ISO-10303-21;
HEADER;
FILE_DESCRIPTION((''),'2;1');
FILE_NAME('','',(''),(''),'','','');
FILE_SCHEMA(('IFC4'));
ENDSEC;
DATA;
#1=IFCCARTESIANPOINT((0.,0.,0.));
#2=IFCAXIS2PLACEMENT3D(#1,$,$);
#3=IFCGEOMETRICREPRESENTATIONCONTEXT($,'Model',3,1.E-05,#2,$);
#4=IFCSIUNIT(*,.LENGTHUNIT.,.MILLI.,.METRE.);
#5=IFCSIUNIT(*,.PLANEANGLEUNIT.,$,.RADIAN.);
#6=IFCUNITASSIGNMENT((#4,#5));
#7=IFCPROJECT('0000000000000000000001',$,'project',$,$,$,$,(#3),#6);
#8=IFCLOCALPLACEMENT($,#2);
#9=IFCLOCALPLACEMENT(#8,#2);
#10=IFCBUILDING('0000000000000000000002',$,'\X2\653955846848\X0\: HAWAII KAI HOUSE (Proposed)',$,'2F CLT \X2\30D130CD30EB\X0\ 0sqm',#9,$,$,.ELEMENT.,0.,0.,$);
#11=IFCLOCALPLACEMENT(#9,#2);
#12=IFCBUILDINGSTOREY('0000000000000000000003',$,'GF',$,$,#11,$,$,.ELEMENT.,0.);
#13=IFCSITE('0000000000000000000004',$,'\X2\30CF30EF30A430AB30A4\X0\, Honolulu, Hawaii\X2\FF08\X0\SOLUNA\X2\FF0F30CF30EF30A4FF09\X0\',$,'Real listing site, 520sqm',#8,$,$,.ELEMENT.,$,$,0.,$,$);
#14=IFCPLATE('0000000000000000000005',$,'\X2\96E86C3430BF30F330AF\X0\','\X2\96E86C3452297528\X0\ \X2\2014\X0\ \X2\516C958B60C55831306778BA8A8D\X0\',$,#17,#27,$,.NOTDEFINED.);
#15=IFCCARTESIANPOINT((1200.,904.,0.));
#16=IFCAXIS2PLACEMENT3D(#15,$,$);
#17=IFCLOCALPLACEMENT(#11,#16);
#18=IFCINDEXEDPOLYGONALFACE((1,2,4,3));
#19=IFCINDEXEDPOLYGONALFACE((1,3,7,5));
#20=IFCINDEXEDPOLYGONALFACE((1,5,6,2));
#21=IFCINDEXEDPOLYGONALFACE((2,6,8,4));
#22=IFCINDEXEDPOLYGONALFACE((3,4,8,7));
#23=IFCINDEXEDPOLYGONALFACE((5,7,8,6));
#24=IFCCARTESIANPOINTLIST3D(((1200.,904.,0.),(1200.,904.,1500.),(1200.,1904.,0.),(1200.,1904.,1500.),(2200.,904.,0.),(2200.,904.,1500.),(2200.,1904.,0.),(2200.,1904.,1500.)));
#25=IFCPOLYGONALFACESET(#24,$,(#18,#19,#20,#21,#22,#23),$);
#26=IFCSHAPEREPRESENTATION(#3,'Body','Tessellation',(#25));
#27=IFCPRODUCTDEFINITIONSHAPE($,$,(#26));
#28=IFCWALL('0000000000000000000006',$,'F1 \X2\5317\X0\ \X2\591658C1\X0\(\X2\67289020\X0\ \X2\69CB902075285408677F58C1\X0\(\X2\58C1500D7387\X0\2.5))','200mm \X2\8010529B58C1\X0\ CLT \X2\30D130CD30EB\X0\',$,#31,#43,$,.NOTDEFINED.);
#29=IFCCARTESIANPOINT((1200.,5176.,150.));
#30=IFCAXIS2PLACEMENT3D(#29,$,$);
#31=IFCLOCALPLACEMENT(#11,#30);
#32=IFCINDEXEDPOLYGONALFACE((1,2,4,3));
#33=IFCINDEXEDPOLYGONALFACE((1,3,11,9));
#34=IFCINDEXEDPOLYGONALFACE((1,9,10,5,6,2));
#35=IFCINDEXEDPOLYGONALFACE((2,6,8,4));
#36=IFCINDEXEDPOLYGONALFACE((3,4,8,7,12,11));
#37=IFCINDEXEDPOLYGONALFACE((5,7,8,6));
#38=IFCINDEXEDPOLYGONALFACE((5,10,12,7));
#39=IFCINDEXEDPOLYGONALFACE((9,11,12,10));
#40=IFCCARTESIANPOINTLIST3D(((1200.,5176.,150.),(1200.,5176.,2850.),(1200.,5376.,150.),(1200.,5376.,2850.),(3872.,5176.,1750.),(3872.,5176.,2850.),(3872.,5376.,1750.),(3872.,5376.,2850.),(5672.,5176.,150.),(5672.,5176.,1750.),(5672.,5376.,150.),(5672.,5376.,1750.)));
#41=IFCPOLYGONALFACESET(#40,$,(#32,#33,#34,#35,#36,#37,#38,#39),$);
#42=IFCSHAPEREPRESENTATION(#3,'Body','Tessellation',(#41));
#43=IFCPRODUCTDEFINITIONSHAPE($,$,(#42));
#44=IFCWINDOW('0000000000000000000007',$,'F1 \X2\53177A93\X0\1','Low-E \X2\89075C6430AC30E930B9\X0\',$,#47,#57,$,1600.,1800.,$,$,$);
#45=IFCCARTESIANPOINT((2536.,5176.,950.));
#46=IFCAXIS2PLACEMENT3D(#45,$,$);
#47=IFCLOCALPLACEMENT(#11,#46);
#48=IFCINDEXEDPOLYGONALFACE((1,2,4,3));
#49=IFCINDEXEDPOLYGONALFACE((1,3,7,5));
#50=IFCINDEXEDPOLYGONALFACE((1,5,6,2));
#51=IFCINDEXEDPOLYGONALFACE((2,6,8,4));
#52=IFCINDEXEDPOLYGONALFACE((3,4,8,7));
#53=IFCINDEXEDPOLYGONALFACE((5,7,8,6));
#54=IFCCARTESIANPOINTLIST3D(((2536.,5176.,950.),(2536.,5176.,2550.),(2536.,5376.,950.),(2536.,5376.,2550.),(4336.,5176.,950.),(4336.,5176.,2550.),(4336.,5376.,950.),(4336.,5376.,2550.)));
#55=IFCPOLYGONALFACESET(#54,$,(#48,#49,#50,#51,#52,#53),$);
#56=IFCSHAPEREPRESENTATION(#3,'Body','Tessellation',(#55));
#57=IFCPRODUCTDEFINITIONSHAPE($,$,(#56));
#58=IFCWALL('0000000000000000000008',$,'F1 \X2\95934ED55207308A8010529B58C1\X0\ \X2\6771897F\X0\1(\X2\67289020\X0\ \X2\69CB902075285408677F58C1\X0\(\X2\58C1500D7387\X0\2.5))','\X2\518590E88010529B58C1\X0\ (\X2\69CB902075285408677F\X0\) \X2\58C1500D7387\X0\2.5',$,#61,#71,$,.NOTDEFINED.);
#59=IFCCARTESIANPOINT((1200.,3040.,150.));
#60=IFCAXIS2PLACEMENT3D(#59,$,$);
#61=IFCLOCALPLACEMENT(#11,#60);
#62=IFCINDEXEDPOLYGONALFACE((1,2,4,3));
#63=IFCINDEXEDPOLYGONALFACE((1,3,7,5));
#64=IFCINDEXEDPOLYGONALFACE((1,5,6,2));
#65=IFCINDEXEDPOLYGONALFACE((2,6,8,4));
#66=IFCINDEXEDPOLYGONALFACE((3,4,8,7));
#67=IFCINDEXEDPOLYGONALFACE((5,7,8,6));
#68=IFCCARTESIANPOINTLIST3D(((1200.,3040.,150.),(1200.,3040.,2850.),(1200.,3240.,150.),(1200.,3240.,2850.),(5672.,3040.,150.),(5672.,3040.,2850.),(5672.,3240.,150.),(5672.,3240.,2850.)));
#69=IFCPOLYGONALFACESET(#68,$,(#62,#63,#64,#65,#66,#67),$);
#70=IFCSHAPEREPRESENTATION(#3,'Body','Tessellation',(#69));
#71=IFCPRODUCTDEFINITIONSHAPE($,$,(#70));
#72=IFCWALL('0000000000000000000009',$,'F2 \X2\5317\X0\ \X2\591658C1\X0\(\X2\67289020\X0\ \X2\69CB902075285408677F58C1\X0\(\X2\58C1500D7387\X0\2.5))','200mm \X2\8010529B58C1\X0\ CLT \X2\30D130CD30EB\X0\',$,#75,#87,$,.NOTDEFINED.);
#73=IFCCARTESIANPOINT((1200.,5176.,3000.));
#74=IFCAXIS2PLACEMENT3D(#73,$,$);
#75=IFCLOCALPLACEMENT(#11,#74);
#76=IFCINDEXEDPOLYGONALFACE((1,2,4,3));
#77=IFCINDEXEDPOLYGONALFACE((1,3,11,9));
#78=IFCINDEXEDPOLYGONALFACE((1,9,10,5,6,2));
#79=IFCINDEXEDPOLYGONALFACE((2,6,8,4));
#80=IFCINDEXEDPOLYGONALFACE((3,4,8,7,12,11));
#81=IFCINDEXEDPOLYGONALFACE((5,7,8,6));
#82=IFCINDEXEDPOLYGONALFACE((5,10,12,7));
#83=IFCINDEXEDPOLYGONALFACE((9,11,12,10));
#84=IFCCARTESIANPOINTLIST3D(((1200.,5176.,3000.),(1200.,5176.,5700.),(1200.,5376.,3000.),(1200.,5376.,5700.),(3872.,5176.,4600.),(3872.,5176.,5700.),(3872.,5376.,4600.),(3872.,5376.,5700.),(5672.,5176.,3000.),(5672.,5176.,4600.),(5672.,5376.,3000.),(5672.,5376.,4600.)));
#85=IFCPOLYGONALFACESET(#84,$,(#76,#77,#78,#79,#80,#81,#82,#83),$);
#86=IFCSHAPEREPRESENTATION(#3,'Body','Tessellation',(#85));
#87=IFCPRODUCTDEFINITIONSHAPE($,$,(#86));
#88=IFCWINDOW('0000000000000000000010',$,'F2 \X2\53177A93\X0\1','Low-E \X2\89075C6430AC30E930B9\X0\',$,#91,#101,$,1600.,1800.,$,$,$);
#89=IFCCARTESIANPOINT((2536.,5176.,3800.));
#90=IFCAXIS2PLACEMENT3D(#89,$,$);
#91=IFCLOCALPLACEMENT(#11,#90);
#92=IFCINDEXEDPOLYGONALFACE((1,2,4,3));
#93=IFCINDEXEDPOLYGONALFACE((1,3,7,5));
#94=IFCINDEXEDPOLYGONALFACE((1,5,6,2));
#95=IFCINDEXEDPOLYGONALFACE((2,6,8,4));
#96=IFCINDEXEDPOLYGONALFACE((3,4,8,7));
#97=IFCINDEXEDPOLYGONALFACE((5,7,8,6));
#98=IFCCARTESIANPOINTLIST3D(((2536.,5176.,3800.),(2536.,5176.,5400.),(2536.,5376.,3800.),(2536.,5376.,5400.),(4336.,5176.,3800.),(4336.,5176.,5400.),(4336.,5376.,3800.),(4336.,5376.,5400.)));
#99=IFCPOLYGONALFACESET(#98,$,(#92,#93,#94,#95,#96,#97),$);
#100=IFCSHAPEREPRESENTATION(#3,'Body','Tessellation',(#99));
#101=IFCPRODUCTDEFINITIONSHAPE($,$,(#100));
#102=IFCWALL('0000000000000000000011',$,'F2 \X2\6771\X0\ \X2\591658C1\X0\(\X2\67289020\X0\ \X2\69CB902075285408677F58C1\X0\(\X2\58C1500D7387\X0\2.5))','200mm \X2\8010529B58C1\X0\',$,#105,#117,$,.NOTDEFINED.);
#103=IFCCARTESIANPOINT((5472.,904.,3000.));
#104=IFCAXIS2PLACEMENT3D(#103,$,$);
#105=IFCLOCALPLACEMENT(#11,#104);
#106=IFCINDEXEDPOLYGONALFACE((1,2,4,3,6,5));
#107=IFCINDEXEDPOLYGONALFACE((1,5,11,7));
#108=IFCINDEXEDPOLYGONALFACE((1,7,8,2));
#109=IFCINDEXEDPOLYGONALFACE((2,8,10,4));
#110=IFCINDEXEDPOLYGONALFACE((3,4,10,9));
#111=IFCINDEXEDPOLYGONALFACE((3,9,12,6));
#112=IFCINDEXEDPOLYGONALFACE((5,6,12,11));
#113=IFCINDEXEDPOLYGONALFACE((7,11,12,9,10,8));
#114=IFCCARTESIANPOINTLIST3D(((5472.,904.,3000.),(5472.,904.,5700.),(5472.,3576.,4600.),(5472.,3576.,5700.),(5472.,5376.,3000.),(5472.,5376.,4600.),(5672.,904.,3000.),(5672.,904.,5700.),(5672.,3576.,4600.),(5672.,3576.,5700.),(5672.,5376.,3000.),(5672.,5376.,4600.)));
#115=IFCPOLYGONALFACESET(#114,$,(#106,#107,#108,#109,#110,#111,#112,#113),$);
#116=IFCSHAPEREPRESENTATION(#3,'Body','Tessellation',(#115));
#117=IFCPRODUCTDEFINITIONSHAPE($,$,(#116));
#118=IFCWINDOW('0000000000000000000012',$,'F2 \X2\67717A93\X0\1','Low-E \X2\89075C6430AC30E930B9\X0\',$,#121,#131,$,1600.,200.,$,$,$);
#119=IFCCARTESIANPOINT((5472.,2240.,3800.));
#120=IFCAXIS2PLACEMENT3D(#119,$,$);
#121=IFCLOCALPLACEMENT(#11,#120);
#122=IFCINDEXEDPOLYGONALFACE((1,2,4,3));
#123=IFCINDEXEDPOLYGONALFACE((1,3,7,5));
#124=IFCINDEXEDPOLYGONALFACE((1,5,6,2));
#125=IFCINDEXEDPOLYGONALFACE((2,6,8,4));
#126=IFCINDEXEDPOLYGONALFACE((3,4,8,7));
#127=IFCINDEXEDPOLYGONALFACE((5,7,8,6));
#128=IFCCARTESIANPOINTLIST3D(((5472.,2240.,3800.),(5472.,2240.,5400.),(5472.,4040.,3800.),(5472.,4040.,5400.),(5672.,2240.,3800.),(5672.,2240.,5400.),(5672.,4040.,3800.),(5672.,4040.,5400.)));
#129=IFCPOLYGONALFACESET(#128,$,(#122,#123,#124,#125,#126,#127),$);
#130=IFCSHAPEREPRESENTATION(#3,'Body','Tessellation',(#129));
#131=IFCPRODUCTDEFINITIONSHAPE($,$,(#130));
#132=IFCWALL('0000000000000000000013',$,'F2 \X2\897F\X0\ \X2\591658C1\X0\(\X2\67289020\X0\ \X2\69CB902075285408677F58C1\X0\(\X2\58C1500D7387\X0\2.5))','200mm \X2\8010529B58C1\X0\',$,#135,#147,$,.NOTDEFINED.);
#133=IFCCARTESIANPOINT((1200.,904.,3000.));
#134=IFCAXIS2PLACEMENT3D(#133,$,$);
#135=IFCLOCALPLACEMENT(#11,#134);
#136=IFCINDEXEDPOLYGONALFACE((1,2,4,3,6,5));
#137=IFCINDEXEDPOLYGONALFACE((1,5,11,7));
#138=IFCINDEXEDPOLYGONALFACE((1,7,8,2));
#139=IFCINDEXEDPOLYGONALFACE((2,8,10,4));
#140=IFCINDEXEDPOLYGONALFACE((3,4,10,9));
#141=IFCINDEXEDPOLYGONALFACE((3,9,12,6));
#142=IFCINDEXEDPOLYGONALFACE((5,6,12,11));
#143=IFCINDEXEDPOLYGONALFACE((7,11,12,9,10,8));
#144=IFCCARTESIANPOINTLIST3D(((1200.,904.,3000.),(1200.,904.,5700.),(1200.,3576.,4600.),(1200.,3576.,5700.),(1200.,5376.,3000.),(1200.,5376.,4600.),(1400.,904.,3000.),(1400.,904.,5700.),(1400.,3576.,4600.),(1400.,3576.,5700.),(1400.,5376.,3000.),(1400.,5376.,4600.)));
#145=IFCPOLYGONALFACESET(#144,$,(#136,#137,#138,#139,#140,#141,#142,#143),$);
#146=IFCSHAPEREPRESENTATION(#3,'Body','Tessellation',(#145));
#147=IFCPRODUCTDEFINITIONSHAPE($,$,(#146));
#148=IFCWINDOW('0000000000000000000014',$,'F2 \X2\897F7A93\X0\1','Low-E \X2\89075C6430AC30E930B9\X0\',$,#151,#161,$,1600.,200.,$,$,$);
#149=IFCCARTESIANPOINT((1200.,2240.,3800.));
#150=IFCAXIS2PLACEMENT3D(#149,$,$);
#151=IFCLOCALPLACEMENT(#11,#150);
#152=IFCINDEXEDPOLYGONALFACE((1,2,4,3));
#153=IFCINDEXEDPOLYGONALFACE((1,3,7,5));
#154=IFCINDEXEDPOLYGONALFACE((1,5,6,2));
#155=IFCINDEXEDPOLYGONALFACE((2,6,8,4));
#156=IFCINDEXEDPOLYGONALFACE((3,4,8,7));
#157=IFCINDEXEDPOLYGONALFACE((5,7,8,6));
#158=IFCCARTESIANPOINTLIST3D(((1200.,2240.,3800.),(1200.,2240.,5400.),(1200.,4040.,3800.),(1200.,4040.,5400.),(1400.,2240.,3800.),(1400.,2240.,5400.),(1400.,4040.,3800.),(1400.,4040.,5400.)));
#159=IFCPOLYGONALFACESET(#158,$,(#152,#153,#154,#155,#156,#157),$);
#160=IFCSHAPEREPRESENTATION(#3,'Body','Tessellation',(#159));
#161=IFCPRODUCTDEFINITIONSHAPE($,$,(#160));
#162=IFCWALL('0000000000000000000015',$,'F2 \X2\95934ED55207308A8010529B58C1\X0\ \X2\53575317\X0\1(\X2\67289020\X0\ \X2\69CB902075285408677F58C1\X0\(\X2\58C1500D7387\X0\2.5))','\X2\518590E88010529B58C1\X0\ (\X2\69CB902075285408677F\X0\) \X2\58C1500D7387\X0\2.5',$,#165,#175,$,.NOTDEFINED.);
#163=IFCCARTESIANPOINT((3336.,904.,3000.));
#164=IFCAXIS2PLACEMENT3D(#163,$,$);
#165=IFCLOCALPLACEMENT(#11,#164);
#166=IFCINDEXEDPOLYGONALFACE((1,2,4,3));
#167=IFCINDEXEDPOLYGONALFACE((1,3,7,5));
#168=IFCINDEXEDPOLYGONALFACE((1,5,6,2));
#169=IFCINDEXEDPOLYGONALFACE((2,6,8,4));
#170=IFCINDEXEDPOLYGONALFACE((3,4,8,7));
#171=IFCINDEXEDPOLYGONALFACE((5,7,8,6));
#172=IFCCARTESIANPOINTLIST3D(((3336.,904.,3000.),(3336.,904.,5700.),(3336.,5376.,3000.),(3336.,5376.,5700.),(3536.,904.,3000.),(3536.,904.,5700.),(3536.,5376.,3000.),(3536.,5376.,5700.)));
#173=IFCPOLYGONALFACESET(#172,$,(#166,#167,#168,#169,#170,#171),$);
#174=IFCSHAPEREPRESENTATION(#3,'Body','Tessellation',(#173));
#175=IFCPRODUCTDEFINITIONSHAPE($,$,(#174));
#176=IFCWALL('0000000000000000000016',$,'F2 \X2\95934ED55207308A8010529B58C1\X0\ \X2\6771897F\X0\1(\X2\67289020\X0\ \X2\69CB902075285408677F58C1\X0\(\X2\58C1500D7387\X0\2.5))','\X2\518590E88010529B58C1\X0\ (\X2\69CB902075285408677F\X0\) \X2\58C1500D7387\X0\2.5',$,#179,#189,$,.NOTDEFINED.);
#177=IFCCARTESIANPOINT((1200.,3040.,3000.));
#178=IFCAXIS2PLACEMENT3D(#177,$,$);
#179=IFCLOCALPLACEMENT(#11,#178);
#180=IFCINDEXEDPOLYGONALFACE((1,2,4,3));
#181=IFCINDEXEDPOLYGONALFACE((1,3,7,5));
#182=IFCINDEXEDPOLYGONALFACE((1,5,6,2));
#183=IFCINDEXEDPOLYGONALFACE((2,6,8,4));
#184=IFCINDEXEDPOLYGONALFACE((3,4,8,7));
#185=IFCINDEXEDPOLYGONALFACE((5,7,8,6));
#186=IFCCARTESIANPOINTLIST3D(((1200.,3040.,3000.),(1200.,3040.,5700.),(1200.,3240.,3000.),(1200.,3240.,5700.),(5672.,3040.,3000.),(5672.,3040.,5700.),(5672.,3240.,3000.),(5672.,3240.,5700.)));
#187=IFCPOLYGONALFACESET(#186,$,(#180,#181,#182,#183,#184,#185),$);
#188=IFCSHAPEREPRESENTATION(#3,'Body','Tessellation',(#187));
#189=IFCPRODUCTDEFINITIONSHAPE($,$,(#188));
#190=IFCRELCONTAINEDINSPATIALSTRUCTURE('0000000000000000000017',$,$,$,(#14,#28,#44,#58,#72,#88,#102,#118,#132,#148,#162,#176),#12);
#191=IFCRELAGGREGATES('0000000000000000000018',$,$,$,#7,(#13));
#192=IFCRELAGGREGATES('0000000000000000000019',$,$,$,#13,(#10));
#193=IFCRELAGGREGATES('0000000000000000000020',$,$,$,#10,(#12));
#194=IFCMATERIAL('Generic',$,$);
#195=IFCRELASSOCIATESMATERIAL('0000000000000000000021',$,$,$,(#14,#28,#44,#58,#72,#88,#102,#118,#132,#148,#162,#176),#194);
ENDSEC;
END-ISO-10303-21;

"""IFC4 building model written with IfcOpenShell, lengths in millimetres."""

from ifc_helpers import new_model, si_unit, frame, frame_2d, origin, place, context, project, spatial, rectangle, extrude, material, element, fill, save


model = new_model("IFC4")

# Units and contexts
model_context = context("Model", 3, precision=1e-05, world=origin())
ifc_project = project(units=[si_unit("LENGTHUNIT", "METRE", prefix="MILLI"), si_unit("PLANEANGLEUNIT", "RADIAN")], contexts=[model_context])

# Site, building, storey
site_placement = place(None, origin())
site = spatial("IfcSite", under=ifc_project, at=site_placement, Name="ハワイカイ, Honolulu, Hawaii（SOLUNA／ハワイ）", ObjectType="Real listing site, 520sqm", CompositionType="ELEMENT", RefElevation=0.0)
building_placement = place(site_placement, origin())
building = spatial("IfcBuilding", under=site, at=building_placement, Name="改善案: HAWAII KAI HOUSE (Proposed)", ObjectType="2F CLT パネル 0sqm", CompositionType="ELEMENT", ElevationOfRefHeight=0.0, ElevationOfTerrain=0.0)
storey_placement = place(building_placement, origin())
storey = spatial("IfcBuildingStorey", under=building, at=storey_placement, Name="GF", CompositionType="ELEMENT", Elevation=0.0)

# Plate
ifc_material_1 = material(Name="Generic")
plate_placement = place(storey_placement, frame((1200.0, 904.0, 0.0)))
element("IfcPlate", 1, at=plate_placement, inside=storey, material=ifc_material_1, Name="雨水タンク", Description="雨水利用 — 公開情報で確認", PredefinedType="NOTDEFINED", context=model_context, shape_type="SweptSolid", body=[
    extrude(rectangle(XDim=1000.0, YDim=1000.0, at=frame_2d((500.0, 500.0))), frame((1200.0, 904.0, 0.0)), (0.0, 0.0, 1.0), 1500.0),
])

# Wall, opening, window
wall_1_placement = place(storey_placement, frame((1200.0, 5176.0, 150.0)))
wall_1 = element("IfcWall", 2, at=wall_1_placement, inside=storey, material=ifc_material_1, Name="F1 北 外壁(木造 構造用合板壁(壁倍率2.5))", Description="200mm 耐力壁 CLT パネル", PredefinedType="NOTDEFINED", context=model_context, shape_type="SweptSolid", body=[
    extrude(rectangle(XDim=4472.0, YDim=200.0, at=frame_2d((2236.0, 100.0))), frame((1200.0, 5176.0, 150.0)), (0.0, 0.0, 1.0), 2700.0),
])
opening_1_placement = place(storey_placement, frame((2536.0, 5176.0, 950.0)))
opening_1 = element("IfcOpeningElement", 3, at=opening_1_placement, cuts=wall_1, PredefinedType="NOTDEFINED", context=model_context, shape_type="SweptSolid", body=[
    extrude(rectangle(XDim=1800.0, YDim=200.0, at=frame_2d((900.0, 100.0))), frame((2536.0, 5176.0, 950.0)), (0.0, 0.0, 1.0), 1600.0),
])
window_1_placement = place(storey_placement, frame((2536.0, 5176.0, 950.0)))
window_1 = element("IfcWindow", 4, at=window_1_placement, inside=storey, material=ifc_material_1, Name="F1 北窓1", Description="Low-E 複層ガラス", OverallHeight=1600.0, OverallWidth=1800.0, context=model_context, shape_type="SweptSolid", body=[
    extrude(rectangle(XDim=1800.0, YDim=200.0, at=frame_2d((900.0, 100.0))), frame((2536.0, 5176.0, 950.0)), (0.0, 0.0, 1.0), 1600.0),
])
fill(opening_1, window_1)

# Wall
wall_2_placement = place(storey_placement, frame((1200.0, 3040.0, 150.0)))
element("IfcWall", 5, at=wall_2_placement, inside=storey, material=ifc_material_1, Name="F1 間仕切り耐力壁 東西1(木造 構造用合板壁(壁倍率2.5))", Description="内部耐力壁 (構造用合板) 壁倍率2.5", PredefinedType="NOTDEFINED", context=model_context, shape_type="SweptSolid", body=[
    extrude(rectangle(XDim=4472.0, YDim=200.0, at=frame_2d((2236.0, 100.0))), frame((1200.0, 3040.0, 150.0)), (0.0, 0.0, 1.0), 2700.0),
])

# Walls, openings, windows
wall_3_placement = place(storey_placement, frame((1200.0, 5176.0, 3000.0)))
wall_3 = element("IfcWall", 6, at=wall_3_placement, inside=storey, material=ifc_material_1, Name="F2 北 外壁(木造 構造用合板壁(壁倍率2.5))", Description="200mm 耐力壁 CLT パネル", PredefinedType="NOTDEFINED", context=model_context, shape_type="SweptSolid", body=[
    extrude(rectangle(XDim=4472.0, YDim=200.0, at=frame_2d((2236.0, 100.0))), frame((1200.0, 5176.0, 3000.0)), (0.0, 0.0, 1.0), 2700.0),
])
opening_2_placement = place(storey_placement, frame((2536.0, 5176.0, 3800.0)))
opening_2 = element("IfcOpeningElement", 7, at=opening_2_placement, cuts=wall_3, PredefinedType="NOTDEFINED", context=model_context, shape_type="SweptSolid", body=[
    extrude(rectangle(XDim=1800.0, YDim=200.0, at=frame_2d((900.0, 100.0))), frame((2536.0, 5176.0, 3800.0)), (0.0, 0.0, 1.0), 1600.0),
])
window_2_placement = place(storey_placement, frame((2536.0, 5176.0, 3800.0)))
window_2 = element("IfcWindow", 8, at=window_2_placement, inside=storey, material=ifc_material_1, Name="F2 北窓1", Description="Low-E 複層ガラス", OverallHeight=1600.0, OverallWidth=1800.0, context=model_context, shape_type="SweptSolid", body=[
    extrude(rectangle(XDim=1800.0, YDim=200.0, at=frame_2d((900.0, 100.0))), frame((2536.0, 5176.0, 3800.0)), (0.0, 0.0, 1.0), 1600.0),
])
fill(opening_2, window_2)
wall_4_placement = place(storey_placement, frame((5472.0, 904.0, 3000.0)))
wall_4 = element("IfcWall", 9, at=wall_4_placement, inside=storey, material=ifc_material_1, Name="F2 東 外壁(木造 構造用合板壁(壁倍率2.5))", Description="200mm 耐力壁", PredefinedType="NOTDEFINED", context=model_context, shape_type="SweptSolid", body=[
    extrude(rectangle(XDim=200.0, YDim=4472.0, at=frame_2d((100.0, 2236.0))), frame((5472.0, 904.0, 3000.0)), (0.0, 0.0, 1.0), 2700.0),
])
opening_3_placement = place(storey_placement, frame((5472.0, 2240.0, 3800.0)))
opening_3 = element("IfcOpeningElement", 10, at=opening_3_placement, cuts=wall_4, PredefinedType="NOTDEFINED", context=model_context, shape_type="SweptSolid", body=[
    extrude(rectangle(XDim=200.0, YDim=1800.0, at=frame_2d((100.0, 900.0))), frame((5472.0, 2240.0, 3800.0)), (0.0, 0.0, 1.0), 1600.0),
])
window_3_placement = place(storey_placement, frame((5472.0, 2240.0, 3800.0)))
window_3 = element("IfcWindow", 11, at=window_3_placement, inside=storey, material=ifc_material_1, Name="F2 東窓1", Description="Low-E 複層ガラス", OverallHeight=1600.0, OverallWidth=200.0, context=model_context, shape_type="SweptSolid", body=[
    extrude(rectangle(XDim=200.0, YDim=1800.0, at=frame_2d((100.0, 900.0))), frame((5472.0, 2240.0, 3800.0)), (0.0, 0.0, 1.0), 1600.0),
])
fill(opening_3, window_3)
wall_5_placement = place(storey_placement, frame((1200.0, 904.0, 3000.0)))
wall_5 = element("IfcWall", 12, at=wall_5_placement, inside=storey, material=ifc_material_1, Name="F2 西 外壁(木造 構造用合板壁(壁倍率2.5))", Description="200mm 耐力壁", PredefinedType="NOTDEFINED", context=model_context, shape_type="SweptSolid", body=[
    extrude(rectangle(XDim=200.0, YDim=4472.0, at=frame_2d((100.0, 2236.0))), frame((1200.0, 904.0, 3000.0)), (0.0, 0.0, 1.0), 2700.0),
])
opening_4_placement = place(storey_placement, frame((1200.0, 2240.0, 3800.0)))
opening_4 = element("IfcOpeningElement", 13, at=opening_4_placement, cuts=wall_5, PredefinedType="NOTDEFINED", context=model_context, shape_type="SweptSolid", body=[
    extrude(rectangle(XDim=200.0, YDim=1800.0, at=frame_2d((100.0, 900.0))), frame((1200.0, 2240.0, 3800.0)), (0.0, 0.0, 1.0), 1600.0),
])
window_4_placement = place(storey_placement, frame((1200.0, 2240.0, 3800.0)))
window_4 = element("IfcWindow", 14, at=window_4_placement, inside=storey, material=ifc_material_1, Name="F2 西窓1", Description="Low-E 複層ガラス", OverallHeight=1600.0, OverallWidth=200.0, context=model_context, shape_type="SweptSolid", body=[
    extrude(rectangle(XDim=200.0, YDim=1800.0, at=frame_2d((100.0, 900.0))), frame((1200.0, 2240.0, 3800.0)), (0.0, 0.0, 1.0), 1600.0),
])
fill(opening_4, window_4)

# Walls
wall_6_placement = place(storey_placement, frame((3336.0, 904.0, 3000.0)))
element("IfcWall", 15, at=wall_6_placement, inside=storey, material=ifc_material_1, Name="F2 間仕切り耐力壁 南北1(木造 構造用合板壁(壁倍率2.5))", Description="内部耐力壁 (構造用合板) 壁倍率2.5", PredefinedType="NOTDEFINED", context=model_context, shape_type="SweptSolid", body=[
    extrude(rectangle(XDim=200.0, YDim=4472.0, at=frame_2d((100.0, 2236.0))), frame((3336.0, 904.0, 3000.0)), (0.0, 0.0, 1.0), 2700.0),
])
wall_7_placement = place(storey_placement, frame((1200.0, 3040.0, 3000.0)))
element("IfcWall", 16, at=wall_7_placement, inside=storey, material=ifc_material_1, Name="F2 間仕切り耐力壁 東西1(木造 構造用合板壁(壁倍率2.5))", Description="内部耐力壁 (構造用合板) 壁倍率2.5", PredefinedType="NOTDEFINED", context=model_context, shape_type="SweptSolid", body=[
    extrude(rectangle(XDim=4472.0, YDim=200.0, at=frame_2d((2236.0, 100.0))), frame((1200.0, 3040.0, 3000.0)), (0.0, 0.0, 1.0), 2700.0),
])

save(model, "model.ifc")
